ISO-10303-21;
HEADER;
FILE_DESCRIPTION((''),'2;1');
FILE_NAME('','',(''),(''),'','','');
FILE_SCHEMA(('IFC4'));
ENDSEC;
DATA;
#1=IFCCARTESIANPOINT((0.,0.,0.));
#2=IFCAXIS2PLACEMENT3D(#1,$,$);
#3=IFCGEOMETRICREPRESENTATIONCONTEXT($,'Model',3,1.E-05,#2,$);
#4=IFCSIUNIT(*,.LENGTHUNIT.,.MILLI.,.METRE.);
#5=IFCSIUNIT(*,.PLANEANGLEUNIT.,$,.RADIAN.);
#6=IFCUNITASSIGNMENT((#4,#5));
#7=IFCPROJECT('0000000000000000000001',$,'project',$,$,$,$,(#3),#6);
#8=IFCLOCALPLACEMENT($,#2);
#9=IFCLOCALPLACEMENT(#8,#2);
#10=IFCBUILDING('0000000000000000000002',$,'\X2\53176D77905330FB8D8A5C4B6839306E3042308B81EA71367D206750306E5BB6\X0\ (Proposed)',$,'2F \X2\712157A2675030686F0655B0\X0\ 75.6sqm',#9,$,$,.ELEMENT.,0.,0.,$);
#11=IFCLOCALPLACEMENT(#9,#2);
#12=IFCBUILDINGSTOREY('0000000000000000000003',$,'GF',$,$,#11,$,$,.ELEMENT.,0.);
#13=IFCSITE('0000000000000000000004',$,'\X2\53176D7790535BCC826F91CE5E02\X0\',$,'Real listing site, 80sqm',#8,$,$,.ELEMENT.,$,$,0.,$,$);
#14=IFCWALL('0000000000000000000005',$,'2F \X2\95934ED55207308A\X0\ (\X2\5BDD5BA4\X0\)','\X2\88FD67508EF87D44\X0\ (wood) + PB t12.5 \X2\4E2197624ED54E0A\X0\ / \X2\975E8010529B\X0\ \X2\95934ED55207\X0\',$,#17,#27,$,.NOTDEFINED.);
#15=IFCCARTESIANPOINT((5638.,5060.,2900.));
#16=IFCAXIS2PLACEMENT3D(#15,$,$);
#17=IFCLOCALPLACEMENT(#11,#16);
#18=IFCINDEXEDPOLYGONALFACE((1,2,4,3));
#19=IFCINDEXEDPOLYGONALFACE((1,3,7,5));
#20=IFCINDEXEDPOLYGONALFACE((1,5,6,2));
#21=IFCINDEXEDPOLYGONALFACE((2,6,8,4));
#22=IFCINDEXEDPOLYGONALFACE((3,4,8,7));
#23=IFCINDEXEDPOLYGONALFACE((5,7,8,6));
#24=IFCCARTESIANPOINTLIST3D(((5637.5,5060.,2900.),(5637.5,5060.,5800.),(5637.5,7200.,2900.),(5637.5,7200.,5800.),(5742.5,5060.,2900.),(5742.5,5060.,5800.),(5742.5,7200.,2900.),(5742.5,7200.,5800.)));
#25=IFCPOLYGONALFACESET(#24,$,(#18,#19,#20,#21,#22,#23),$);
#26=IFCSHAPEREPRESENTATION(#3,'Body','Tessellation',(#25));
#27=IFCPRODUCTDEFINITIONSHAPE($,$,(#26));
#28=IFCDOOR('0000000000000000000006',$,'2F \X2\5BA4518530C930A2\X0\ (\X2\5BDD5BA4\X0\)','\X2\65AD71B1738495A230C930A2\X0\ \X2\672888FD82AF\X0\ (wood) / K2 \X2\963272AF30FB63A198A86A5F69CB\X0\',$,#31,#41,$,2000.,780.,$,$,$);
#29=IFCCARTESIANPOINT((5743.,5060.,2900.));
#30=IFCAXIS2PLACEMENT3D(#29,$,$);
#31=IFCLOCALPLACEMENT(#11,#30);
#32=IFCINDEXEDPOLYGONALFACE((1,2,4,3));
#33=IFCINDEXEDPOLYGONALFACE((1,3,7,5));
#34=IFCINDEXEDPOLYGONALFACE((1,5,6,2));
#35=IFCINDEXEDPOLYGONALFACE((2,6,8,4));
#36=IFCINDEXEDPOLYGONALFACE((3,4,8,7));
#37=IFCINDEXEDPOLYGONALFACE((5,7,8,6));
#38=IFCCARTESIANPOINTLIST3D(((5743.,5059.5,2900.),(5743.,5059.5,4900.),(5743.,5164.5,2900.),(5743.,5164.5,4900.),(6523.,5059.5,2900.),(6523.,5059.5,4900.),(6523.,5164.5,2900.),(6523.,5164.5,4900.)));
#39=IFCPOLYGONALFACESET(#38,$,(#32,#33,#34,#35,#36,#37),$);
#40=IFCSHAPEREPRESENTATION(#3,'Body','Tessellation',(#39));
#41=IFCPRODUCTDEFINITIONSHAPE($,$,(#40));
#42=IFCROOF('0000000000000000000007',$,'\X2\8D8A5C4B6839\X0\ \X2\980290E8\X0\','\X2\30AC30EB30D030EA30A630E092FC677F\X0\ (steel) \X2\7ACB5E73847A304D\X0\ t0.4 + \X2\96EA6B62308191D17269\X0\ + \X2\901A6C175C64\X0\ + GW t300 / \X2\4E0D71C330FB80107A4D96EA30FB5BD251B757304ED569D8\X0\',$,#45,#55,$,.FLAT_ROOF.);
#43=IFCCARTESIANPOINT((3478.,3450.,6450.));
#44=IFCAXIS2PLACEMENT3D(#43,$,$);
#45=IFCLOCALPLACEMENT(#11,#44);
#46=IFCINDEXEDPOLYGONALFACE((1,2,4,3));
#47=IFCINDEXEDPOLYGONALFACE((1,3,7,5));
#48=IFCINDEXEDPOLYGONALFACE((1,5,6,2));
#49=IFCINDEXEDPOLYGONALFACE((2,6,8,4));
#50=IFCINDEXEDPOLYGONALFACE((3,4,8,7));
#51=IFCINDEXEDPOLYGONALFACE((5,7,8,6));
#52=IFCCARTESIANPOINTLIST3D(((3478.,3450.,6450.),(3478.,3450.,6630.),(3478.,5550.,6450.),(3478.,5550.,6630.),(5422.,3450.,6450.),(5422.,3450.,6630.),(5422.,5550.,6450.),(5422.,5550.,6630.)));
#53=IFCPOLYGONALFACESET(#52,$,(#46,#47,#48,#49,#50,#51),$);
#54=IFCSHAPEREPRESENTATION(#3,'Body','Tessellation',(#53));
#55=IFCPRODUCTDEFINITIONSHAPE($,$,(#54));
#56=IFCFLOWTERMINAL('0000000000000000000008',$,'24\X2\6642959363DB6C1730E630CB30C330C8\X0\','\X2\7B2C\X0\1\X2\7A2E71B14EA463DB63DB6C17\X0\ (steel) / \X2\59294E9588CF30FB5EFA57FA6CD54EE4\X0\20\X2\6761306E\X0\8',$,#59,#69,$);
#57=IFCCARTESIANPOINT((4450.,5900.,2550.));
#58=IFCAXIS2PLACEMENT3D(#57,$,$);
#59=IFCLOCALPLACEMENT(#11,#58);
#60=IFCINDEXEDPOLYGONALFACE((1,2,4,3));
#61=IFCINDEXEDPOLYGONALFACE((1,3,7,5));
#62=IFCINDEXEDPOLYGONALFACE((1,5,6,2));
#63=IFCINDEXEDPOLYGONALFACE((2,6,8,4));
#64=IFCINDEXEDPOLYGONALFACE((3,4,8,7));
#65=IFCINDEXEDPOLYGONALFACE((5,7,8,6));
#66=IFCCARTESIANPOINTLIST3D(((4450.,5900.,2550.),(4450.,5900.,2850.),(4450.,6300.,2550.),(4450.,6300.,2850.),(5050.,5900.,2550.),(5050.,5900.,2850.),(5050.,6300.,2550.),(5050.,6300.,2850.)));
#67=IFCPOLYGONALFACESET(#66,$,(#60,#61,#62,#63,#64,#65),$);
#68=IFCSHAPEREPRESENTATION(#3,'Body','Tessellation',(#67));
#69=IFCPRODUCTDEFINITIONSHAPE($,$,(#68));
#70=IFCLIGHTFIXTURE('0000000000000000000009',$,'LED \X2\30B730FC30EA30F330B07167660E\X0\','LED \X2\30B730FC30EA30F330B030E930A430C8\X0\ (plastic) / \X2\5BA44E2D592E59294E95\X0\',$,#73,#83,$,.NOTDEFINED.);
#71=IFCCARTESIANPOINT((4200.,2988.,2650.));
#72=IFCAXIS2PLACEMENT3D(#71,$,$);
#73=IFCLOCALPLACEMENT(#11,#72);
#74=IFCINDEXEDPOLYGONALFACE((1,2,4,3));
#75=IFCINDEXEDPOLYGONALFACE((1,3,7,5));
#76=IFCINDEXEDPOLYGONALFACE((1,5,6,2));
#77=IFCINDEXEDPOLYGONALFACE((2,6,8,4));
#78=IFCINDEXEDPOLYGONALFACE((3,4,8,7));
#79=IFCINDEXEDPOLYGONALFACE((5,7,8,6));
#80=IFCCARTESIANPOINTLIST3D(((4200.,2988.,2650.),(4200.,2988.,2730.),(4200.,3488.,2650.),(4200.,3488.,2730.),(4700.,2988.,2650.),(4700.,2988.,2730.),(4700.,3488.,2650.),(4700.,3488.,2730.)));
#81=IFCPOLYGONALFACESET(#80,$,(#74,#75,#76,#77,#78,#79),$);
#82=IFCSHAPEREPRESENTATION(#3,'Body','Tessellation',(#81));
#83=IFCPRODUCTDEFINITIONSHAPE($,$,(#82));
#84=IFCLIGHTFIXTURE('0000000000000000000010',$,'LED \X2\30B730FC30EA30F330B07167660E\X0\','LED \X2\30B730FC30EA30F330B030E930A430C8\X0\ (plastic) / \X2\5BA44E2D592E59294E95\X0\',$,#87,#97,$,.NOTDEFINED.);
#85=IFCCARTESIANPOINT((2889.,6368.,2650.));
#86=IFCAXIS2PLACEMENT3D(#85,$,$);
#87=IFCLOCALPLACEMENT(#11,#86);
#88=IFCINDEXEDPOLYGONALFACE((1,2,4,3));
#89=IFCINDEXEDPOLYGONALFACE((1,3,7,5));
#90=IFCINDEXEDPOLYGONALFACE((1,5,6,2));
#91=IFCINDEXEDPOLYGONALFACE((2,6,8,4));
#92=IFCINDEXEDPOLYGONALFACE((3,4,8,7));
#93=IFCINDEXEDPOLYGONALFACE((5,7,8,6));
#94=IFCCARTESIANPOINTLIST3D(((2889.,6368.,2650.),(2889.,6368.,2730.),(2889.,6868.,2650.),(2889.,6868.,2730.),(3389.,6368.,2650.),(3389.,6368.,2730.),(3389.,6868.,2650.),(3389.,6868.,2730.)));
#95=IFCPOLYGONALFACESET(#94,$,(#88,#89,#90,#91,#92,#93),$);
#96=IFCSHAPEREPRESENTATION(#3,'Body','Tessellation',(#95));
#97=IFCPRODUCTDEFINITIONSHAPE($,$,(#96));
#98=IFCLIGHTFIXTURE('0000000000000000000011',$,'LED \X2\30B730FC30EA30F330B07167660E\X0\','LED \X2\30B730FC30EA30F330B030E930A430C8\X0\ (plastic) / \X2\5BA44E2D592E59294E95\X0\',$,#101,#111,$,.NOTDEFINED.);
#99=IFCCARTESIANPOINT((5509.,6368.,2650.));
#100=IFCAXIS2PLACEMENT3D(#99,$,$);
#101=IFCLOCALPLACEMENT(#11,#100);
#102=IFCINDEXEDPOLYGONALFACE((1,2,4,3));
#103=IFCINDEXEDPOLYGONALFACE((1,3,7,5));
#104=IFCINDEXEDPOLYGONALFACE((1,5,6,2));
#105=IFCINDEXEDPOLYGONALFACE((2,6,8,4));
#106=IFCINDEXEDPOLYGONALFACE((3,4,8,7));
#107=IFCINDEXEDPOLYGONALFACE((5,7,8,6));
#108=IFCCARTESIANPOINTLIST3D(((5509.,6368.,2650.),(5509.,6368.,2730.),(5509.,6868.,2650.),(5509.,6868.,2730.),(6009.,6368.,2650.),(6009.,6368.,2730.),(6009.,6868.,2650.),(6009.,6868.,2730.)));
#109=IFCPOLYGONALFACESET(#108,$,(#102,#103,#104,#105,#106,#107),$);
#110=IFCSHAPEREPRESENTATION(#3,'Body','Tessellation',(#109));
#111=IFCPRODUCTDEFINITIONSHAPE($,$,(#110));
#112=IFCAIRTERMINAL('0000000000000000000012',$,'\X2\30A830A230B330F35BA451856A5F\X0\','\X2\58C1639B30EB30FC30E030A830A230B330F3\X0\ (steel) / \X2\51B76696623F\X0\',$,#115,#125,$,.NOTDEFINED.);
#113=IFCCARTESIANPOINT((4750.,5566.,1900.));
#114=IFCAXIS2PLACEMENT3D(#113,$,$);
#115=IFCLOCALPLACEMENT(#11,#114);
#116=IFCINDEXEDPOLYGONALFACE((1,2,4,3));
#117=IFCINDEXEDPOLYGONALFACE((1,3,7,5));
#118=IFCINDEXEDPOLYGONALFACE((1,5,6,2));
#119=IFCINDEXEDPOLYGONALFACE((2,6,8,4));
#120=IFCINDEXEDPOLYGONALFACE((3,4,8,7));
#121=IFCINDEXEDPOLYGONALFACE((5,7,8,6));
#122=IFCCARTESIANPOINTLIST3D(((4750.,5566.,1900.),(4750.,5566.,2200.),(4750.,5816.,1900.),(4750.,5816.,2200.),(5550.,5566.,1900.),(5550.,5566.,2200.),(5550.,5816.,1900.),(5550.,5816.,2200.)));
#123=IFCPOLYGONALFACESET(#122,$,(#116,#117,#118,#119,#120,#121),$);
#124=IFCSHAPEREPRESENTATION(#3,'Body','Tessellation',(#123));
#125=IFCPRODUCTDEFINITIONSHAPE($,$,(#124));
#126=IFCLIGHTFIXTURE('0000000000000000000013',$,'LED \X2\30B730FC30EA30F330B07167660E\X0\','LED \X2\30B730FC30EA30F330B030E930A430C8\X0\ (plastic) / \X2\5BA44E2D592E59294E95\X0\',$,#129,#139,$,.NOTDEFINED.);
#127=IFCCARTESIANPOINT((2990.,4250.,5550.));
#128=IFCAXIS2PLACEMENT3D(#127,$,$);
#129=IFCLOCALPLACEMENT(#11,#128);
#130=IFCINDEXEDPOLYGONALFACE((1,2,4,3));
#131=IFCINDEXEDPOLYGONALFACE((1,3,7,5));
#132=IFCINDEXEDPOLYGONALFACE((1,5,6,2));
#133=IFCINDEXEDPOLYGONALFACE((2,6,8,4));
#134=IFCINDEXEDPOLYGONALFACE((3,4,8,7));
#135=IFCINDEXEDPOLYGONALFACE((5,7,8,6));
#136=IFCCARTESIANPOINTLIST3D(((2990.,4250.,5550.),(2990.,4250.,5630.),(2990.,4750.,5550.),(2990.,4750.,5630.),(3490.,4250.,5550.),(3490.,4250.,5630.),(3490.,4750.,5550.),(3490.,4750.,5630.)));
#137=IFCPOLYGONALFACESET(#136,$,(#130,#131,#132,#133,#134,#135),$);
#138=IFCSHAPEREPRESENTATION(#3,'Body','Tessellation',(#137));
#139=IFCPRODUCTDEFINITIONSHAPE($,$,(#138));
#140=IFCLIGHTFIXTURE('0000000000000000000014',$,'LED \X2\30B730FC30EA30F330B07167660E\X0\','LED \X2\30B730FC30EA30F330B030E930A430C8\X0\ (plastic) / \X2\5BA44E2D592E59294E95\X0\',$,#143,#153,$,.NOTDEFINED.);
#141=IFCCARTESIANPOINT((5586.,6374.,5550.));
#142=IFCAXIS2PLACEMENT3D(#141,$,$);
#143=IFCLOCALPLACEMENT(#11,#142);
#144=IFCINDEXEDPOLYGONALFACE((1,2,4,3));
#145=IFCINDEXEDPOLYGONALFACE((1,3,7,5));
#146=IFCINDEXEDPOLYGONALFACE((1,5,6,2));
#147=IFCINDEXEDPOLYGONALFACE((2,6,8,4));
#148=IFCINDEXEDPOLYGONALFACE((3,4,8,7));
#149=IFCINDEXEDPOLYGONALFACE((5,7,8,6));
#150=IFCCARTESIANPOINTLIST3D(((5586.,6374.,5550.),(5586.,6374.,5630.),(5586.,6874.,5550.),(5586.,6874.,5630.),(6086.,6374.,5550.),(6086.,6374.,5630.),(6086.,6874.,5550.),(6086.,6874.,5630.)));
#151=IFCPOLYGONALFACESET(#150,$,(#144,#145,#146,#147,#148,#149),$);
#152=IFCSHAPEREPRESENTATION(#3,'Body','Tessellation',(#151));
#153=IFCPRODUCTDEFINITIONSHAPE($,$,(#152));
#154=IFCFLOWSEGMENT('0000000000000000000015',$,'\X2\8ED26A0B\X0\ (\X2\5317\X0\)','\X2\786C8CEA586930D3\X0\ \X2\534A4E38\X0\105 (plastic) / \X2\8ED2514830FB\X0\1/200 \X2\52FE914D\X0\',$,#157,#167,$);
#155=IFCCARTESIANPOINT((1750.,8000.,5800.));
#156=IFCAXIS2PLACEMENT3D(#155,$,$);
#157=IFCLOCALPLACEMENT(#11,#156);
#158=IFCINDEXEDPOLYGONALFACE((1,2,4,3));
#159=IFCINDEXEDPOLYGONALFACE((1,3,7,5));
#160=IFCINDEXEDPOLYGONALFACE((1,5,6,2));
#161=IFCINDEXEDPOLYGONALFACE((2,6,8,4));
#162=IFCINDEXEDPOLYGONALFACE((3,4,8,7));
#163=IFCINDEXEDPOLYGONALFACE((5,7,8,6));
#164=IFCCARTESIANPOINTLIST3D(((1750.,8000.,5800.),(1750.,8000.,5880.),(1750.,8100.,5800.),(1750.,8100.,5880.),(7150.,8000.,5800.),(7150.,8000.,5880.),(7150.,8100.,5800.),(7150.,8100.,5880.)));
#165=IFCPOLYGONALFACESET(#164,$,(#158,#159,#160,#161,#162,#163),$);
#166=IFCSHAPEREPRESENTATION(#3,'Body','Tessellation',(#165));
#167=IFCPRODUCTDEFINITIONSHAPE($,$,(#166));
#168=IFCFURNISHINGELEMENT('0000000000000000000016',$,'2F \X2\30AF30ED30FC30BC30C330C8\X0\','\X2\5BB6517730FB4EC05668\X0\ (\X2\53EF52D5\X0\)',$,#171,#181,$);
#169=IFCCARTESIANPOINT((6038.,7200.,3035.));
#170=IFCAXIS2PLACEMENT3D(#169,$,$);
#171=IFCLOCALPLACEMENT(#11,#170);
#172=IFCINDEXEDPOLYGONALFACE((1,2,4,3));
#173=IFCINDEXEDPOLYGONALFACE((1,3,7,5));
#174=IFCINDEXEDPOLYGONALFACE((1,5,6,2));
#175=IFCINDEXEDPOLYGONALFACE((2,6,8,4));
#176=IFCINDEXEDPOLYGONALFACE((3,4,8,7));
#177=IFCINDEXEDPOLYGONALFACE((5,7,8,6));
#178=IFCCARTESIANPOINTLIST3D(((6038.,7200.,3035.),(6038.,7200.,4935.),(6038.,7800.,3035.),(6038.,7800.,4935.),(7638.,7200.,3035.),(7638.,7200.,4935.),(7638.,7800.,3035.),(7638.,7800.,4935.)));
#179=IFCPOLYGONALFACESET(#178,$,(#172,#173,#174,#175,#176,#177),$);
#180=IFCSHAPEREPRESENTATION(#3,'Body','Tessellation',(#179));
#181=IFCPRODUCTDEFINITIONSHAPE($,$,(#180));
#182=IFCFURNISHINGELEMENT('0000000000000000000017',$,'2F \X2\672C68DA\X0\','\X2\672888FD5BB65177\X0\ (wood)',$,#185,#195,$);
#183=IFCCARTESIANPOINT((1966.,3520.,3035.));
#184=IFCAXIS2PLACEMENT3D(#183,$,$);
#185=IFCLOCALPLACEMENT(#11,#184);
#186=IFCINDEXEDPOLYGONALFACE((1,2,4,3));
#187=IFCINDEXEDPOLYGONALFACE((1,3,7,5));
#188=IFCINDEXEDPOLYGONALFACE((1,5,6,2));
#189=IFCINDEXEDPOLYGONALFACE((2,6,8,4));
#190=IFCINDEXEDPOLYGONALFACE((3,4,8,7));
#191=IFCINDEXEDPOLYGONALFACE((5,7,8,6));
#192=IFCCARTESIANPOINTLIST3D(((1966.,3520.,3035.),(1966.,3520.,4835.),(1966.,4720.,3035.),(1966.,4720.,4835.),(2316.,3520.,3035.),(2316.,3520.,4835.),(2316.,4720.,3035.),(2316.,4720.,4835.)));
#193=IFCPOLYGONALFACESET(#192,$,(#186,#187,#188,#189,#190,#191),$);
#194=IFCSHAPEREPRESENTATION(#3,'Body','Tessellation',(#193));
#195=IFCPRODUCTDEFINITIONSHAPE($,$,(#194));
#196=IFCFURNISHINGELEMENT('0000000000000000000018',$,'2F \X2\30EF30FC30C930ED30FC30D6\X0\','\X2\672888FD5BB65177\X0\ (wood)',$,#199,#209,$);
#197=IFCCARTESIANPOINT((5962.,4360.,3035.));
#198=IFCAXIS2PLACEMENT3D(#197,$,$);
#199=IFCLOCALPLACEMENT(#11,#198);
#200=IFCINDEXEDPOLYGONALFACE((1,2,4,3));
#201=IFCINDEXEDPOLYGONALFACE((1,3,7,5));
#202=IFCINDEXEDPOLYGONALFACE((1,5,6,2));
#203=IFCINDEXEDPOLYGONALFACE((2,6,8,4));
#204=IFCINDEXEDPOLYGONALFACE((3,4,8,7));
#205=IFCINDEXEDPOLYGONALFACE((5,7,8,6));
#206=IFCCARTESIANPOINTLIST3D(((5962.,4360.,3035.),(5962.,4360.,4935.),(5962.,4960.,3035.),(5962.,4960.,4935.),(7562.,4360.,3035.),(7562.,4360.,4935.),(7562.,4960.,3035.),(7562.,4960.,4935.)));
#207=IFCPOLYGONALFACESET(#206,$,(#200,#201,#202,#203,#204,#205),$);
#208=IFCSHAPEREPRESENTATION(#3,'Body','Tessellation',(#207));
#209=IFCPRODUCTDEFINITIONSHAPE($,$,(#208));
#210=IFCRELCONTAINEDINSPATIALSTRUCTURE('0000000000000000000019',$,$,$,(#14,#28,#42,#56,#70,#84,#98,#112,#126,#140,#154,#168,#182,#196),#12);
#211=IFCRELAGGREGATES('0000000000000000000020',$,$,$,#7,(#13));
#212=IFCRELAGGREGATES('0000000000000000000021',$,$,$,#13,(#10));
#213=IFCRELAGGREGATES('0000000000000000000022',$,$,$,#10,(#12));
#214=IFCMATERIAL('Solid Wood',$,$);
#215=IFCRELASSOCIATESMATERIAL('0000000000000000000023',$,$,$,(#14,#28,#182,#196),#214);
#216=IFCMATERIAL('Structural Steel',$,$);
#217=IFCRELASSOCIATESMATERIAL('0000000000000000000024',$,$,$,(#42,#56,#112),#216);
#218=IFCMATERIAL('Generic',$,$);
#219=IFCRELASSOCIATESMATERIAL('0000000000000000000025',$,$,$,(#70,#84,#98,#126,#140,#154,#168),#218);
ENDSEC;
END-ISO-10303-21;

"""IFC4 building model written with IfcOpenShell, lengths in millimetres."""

from ifc_helpers import new_model, si_unit, frame, frame_2d, origin, place, context, project, spatial, rectangle, extrude, material, element, save


model = new_model("IFC4")

# Units and contexts
model_context = context("Model", 3, precision=1e-05, world=origin())
ifc_project = project(units=[si_unit("LENGTHUNIT", "METRE", prefix="MILLI"), si_unit("PLANEANGLEUNIT", "RADIAN")], contexts=[model_context])

# Site, building, storey
site_placement = place(None, origin())
site = spatial("IfcSite", under=ifc_project, at=site_placement, Name="北海道富良野市", ObjectType="Real listing site, 80sqm", CompositionType="ELEMENT", RefElevation=0.0)
building_placement = place(site_placement, origin())
building = spatial("IfcBuilding", under=site, at=building_placement, Name="北海道・越屋根のある自然素材の家 (Proposed)", ObjectType="2F 無垢材と漆喰 75.6sqm", CompositionType="ELEMENT", ElevationOfRefHeight=0.0, ElevationOfTerrain=0.0)
storey_placement = place(building_placement, origin())
storey = spatial("IfcBuildingStorey", under=building, at=storey_placement, Name="GF", CompositionType="ELEMENT", Elevation=0.0)

# Shared definitions
ifc_material_1 = material(Name="Solid Wood")

# Wall
wall_1_placement = place(storey_placement, frame((5638.0, 5060.0, 2900.0)))
element("IfcWall", 1, at=wall_1_placement, inside=storey, material=ifc_material_1, Name="2F 間仕切り (寝室)", Description="製材軸組 (wood) + PB t12.5 両面仕上 / 非耐力 間仕切", PredefinedType="NOTDEFINED", context=model_context, shape_type="SweptSolid", body=[
    extrude(rectangle(XDim=105.0, YDim=2140.0, at=frame_2d((52.0, 1070.0))), frame((5638.0, 5060.0, 2900.0)), (0.0, 0.0, 1.0), 2900.0),
])

# Door
door_placement = place(storey_placement, frame((5743.0, 5060.0, 2900.0)))
element("IfcDoor", 2, at=door_placement, inside=storey, material=ifc_material_1, Name="2F 室内ドア (寝室)", Description="断熱玄関ドア 木製芯 (wood) / K2 防犯・採風機構", OverallHeight=2000.0, OverallWidth=780.0, context=model_context, shape_type="SweptSolid", body=[
    extrude(rectangle(XDim=780.0, YDim=105.0, at=frame_2d((390.0, 52.0))), frame((5743.0, 5060.0, 2900.0)), (0.0, 0.0, 1.0), 2000.0),
])

# Roof
ifc_material_2 = material(Name="Structural Steel")
roof_placement = place(storey_placement, frame((3478.0, 3450.0, 6450.0)))
element("IfcRoof", 3, at=roof_placement, inside=storey, material=ifc_material_2, Name="越屋根 頂部", Description="ガルバリウム鋼板 (steel) 立平葺き t0.4 + 雪止め金物 + 通気層 + GW t300 / 不燃・耐積雪・寒冷地仕様", PredefinedType="FLAT_ROOF", context=model_context, shape_type="SweptSolid", body=[
    extrude(rectangle(XDim=1944.0, YDim=2100.0, at=frame_2d((972.0, 1050.0))), frame((3478.0, 3450.0, 6450.0)), (0.0, 0.0, 1.0), 180.0),
])

# Flow terminal
flow_terminal_placement = place(storey_placement, frame((4450.0, 5900.0, 2550.0)))
element("IfcFlowTerminal", 4, at=flow_terminal_placement, inside=storey, material=ifc_material_2, Name="24時間換気ユニット", Description="第1種熱交換換気 (steel) / 天井裏・建基法令20条の8", context=model_context, shape_type="SweptSolid", body=[
    extrude(rectangle(XDim=600.0, YDim=400.0, at=frame_2d((300.0, 200.0))), frame((4450.0, 5900.0, 2550.0)), (0.0, 0.0, 1.0), 300.0),
])

# Light fixtures
ifc_material_3 = material(Name="Generic")
light_fixture_1_placement = place(storey_placement, frame((4200.0, 2988.0, 2650.0)))
element("IfcLightFixture", 5, at=light_fixture_1_placement, inside=storey, material=ifc_material_3, Name="LED シーリング照明", Description="LED シーリングライト (plastic) / 室中央天井", PredefinedType="NOTDEFINED", context=model_context, shape_type="SweptSolid", body=[
    extrude(rectangle(XDim=500.0, YDim=500.0, at=frame_2d((250.0, 250.0))), frame((4200.0, 2988.0, 2650.0)), (0.0, 0.0, 1.0), 80.0),
])
light_fixture_2_placement = place(storey_placement, frame((2889.0, 6368.0, 2650.0)))
element("IfcLightFixture", 6, at=light_fixture_2_placement, inside=storey, material=ifc_material_3, Name="LED シーリング照明", Description="LED シーリングライト (plastic) / 室中央天井", PredefinedType="NOTDEFINED", context=model_context, shape_type="SweptSolid", body=[
    extrude(rectangle(XDim=500.0, YDim=500.0, at=frame_2d((250.0, 250.0))), frame((2889.0, 6368.0, 2650.0)), (0.0, 0.0, 1.0), 80.0),
])
light_fixture_3_placement = place(storey_placement, frame((5509.0, 6368.0, 2650.0)))
element("IfcLightFixture", 7, at=light_fixture_3_placement, inside=storey, material=ifc_material_3, Name="LED シーリング照明", Description="LED シーリングライト (plastic) / 室中央天井", PredefinedType="NOTDEFINED", context=model_context, shape_type="SweptSolid", body=[
    extrude(rectangle(XDim=500.0, YDim=500.0, at=frame_2d((250.0, 250.0))), frame((5509.0, 6368.0, 2650.0)), (0.0, 0.0, 1.0), 80.0),
])

# Air terminal
air_terminal_placement = place(storey_placement, frame((4750.0, 5566.0, 1900.0)))
element("IfcAirTerminal", 8, at=air_terminal_placement, inside=storey, material=ifc_material_2, Name="エアコン室内機", Description="壁掛ルームエアコン (steel) / 冷暖房", PredefinedType="NOTDEFINED", context=model_context, shape_type="SweptSolid", body=[
    extrude(rectangle(XDim=800.0, YDim=250.0, at=frame_2d((400.0, 125.0))), frame((4750.0, 5566.0, 1900.0)), (0.0, 0.0, 1.0), 300.0),
])

# Light fixtures
light_fixture_4_placement = place(storey_placement, frame((2990.0, 4250.0, 5550.0)))
element("IfcLightFixture", 9, at=light_fixture_4_placement, inside=storey, material=ifc_material_3, Name="LED シーリング照明", Description="LED シーリングライト (plastic) / 室中央天井", PredefinedType="NOTDEFINED", context=model_context, shape_type="SweptSolid", body=[
    extrude(rectangle(XDim=500.0, YDim=500.0, at=frame_2d((250.0, 250.0))), frame((2990.0, 4250.0, 5550.0)), (0.0, 0.0, 1.0), 80.0),
])
light_fixture_5_placement = place(storey_placement, frame((5586.0, 6374.0, 5550.0)))
element("IfcLightFixture", 10, at=light_fixture_5_placement, inside=storey, material=ifc_material_3, Name="LED シーリング照明", Description="LED シーリングライト (plastic) / 室中央天井", PredefinedType="NOTDEFINED", context=model_context, shape_type="SweptSolid", body=[
    extrude(rectangle(XDim=500.0, YDim=500.0, at=frame_2d((250.0, 250.0))), frame((5586.0, 6374.0, 5550.0)), (0.0, 0.0, 1.0), 80.0),
])

# Flow segment
flow_segment_placement = place(storey_placement, frame((1750.0, 8000.0, 5800.0)))
element("IfcFlowSegment", 11, at=flow_segment_placement, inside=storey, material=ifc_material_3, Name="軒樋 (北)", Description="硬質塩ビ 半丸105 (plastic) / 軒先・1/200 勾配", context=model_context, shape_type="SweptSolid", body=[
    extrude(rectangle(XDim=5400.0, YDim=100.0, at=frame_2d((2700.0, 50.0))), frame((1750.0, 8000.0, 5800.0)), (0.0, 0.0, 1.0), 80.0),
])

# Furnishing elements
furnishing_1_placement = place(storey_placement, frame((6038.0, 7200.0, 3035.0)))
element("IfcFurnishingElement", 12, at=furnishing_1_placement, inside=storey, material=ifc_material_3, Name="2F クローゼット", Description="家具・什器 (可動)", context=model_context, shape_type="SweptSolid", body=[
    extrude(rectangle(XDim=1600.0, YDim=600.0, at=frame_2d((800.0, 300.0))), frame((6038.0, 7200.0, 3035.0)), (0.0, 0.0, 1.0), 1900.0),
])
furnishing_2_placement = place(storey_placement, frame((1966.0, 3520.0, 3035.0)))
element("IfcFurnishingElement", 13, at=furnishing_2_placement, inside=storey, material=ifc_material_1, Name="2F 本棚", Description="木製家具 (wood)", context=model_context, shape_type="SweptSolid", body=[
    extrude(rectangle(XDim=350.0, YDim=1200.0, at=frame_2d((175.0, 600.0))), frame((1966.0, 3520.0, 3035.0)), (0.0, 0.0, 1.0), 1800.0),
])
furnishing_3_placement = place(storey_placement, frame((5962.0, 4360.0, 3035.0)))
element("IfcFurnishingElement", 14, at=furnishing_3_placement, inside=storey, material=ifc_material_1, Name="2F ワードローブ", Description="木製家具 (wood)", context=model_context, shape_type="SweptSolid", body=[
    extrude(rectangle(XDim=1600.0, YDim=600.0, at=frame_2d((800.0, 300.0))), frame((5962.0, 4360.0, 3035.0)), (0.0, 0.0, 1.0), 1900.0),
])

save(model, "model.ifc")
